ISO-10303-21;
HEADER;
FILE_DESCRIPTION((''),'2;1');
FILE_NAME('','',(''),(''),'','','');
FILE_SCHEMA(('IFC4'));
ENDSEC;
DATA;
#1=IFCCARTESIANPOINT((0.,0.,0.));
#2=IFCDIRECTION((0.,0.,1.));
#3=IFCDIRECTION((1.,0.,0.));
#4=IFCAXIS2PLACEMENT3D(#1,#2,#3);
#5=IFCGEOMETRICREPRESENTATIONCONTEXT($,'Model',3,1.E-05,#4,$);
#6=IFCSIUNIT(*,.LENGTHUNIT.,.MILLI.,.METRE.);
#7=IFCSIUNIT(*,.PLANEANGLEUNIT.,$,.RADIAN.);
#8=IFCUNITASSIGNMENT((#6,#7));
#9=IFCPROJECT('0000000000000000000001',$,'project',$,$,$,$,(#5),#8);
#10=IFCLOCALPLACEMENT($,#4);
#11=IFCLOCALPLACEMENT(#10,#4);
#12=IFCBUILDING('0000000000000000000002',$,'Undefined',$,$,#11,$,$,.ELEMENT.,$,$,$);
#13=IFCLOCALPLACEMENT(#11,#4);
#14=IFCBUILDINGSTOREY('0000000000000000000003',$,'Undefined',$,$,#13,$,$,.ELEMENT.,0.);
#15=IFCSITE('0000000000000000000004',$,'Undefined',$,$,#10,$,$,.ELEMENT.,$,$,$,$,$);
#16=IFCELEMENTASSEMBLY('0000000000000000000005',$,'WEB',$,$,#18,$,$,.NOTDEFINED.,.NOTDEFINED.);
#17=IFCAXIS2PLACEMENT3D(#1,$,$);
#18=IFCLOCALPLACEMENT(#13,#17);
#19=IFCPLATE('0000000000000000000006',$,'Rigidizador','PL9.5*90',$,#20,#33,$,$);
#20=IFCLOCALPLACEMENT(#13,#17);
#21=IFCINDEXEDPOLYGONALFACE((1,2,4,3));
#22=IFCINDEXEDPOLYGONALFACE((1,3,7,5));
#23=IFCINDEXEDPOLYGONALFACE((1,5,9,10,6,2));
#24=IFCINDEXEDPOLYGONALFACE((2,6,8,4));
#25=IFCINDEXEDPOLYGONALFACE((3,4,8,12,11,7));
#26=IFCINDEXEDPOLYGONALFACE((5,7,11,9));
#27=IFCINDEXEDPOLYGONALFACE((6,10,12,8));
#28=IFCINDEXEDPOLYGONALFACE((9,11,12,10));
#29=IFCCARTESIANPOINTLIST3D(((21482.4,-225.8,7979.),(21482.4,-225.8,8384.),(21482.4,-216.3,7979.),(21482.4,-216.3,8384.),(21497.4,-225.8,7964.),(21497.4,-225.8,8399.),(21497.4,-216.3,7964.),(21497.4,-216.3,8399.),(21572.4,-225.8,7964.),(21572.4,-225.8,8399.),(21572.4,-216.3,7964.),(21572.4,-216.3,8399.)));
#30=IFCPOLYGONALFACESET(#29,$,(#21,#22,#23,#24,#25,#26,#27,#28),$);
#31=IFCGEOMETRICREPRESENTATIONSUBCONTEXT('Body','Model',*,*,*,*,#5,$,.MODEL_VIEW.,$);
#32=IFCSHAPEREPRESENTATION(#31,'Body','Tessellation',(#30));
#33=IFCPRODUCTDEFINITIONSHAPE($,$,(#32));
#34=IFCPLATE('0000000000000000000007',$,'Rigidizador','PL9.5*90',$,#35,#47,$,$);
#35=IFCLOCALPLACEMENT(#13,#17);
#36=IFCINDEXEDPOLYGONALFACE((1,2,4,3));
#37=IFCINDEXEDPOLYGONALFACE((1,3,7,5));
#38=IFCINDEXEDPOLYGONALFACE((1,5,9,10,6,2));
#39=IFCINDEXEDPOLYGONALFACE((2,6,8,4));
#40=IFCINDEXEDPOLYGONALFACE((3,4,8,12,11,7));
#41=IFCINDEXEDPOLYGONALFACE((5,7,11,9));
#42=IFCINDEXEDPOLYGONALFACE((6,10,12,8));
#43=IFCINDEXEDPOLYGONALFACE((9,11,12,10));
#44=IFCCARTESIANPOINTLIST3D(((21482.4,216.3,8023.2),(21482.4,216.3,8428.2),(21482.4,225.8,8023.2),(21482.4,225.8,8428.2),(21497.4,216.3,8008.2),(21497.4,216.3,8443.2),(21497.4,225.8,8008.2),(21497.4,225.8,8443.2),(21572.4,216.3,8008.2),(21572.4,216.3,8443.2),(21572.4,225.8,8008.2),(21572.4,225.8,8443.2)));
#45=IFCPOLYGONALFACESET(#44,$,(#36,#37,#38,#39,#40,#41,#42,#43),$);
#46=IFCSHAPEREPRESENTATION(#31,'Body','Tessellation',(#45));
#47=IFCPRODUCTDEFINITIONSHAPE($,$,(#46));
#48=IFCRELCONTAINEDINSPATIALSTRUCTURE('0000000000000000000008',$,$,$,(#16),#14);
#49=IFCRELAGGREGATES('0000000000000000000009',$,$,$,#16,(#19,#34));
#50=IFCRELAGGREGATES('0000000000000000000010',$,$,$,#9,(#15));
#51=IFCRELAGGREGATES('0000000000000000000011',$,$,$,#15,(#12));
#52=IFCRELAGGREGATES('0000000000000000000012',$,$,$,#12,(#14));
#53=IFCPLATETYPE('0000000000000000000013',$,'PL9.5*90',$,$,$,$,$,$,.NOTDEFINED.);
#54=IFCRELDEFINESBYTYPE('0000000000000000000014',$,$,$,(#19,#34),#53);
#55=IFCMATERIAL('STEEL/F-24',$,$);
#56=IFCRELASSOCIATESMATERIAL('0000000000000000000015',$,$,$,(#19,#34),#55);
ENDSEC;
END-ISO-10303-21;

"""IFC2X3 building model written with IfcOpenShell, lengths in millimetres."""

from ifc_helpers import new_model, si_unit, frame, origin_with_axes, place, context, subcontext, project, spatial, polyline, outline, extrude, material, type_object, element, aggregate, save


model = new_model("IFC2X3")

# Units and contexts
model_context = context("Model", 3, precision=1e-05, world=origin_with_axes())
body_context = subcontext(model_context, "Body", "Model", "MODEL_VIEW")
ifc_project = project(units=[si_unit("LENGTHUNIT", "METRE", prefix="MILLI"), si_unit("PLANEANGLEUNIT", "RADIAN")], contexts=[model_context])

# Site, building, storey
site_placement = place(None, origin_with_axes())
site = spatial("IfcSite", under=ifc_project, at=site_placement, Name="Undefined", CompositionType="ELEMENT")
building_placement = place(site_placement, origin_with_axes())
building = spatial("IfcBuilding", under=site, at=building_placement, Name="Undefined", CompositionType="ELEMENT")
storey_placement = place(building_placement, origin_with_axes())
storey = spatial("IfcBuildingStorey", under=building, at=storey_placement, Name="Undefined", CompositionType="ELEMENT", Elevation=0.0)

# Element assembly, plates
assembly_1_placement = place(storey_placement, origin_with_axes())
assembly_1 = element("IfcElementAssembly", 1, at=assembly_1_placement, inside=storey, Name="WEB", AssemblyPlace="NOTDEFINED", PredefinedType="NOTDEFINED")
ifc_material_1 = material(Name="STEEL/F-24")
plate_type = type_object("IfcPlateType", Name="PL9.5*90", PredefinedType="NOTDEFINED")
plate_1_placement = place(assembly_1_placement, frame((21572.4, -221.1, 7964.0), z_axis=(0.0, 1.0, 0.0), x_axis=(-1.0, 0.0, 0.0)))
plate_1 = element("IfcPlate", 2, at=plate_1_placement, type_object=plate_type, material=ifc_material_1, Name="Rigidizador", Description="PL9.5*90", context=body_context, shape_type="SweptSolid", body=[
    extrude(outline(polyline([(0.0, 0.0), (75.0, 0.0), (90.0, 15.0), (90.0, 420.0), (75.0, 435.0), (0.0, 435.0), (0.0, 0.0)])), frame((0.0, 0.0, -4.7), z_axis=(0.0, 0.0, 1.0), x_axis=(1.0, 0.0, 0.0)), (0.0, 0.0, 1.0), 9.5),
])
plate_2_placement = place(assembly_1_placement, frame((21572.4, 221.0, 8008.2), z_axis=(0.0, 1.0, 0.0), x_axis=(-1.0, 0.0, 0.0)))
plate_2 = element("IfcPlate", 3, at=plate_2_placement, type_object=plate_type, material=ifc_material_1, Name="Rigidizador", Description="PL9.5*90", context=body_context, shape_type="SweptSolid", body=[
    extrude(outline(polyline([(0.0, 0.0), (75.0, 0.0), (90.0, 15.0), (90.0, 420.0), (75.0, 435.0), (0.0, 435.0), (0.0, 0.0)])), frame((0.0, 0.0, -4.7), z_axis=(0.0, 0.0, 1.0), x_axis=(1.0, 0.0, 0.0)), (0.0, 0.0, 1.0), 9.5),
])
aggregate(assembly_1, [plate_1, plate_2])

save(model, "model.ifc")
